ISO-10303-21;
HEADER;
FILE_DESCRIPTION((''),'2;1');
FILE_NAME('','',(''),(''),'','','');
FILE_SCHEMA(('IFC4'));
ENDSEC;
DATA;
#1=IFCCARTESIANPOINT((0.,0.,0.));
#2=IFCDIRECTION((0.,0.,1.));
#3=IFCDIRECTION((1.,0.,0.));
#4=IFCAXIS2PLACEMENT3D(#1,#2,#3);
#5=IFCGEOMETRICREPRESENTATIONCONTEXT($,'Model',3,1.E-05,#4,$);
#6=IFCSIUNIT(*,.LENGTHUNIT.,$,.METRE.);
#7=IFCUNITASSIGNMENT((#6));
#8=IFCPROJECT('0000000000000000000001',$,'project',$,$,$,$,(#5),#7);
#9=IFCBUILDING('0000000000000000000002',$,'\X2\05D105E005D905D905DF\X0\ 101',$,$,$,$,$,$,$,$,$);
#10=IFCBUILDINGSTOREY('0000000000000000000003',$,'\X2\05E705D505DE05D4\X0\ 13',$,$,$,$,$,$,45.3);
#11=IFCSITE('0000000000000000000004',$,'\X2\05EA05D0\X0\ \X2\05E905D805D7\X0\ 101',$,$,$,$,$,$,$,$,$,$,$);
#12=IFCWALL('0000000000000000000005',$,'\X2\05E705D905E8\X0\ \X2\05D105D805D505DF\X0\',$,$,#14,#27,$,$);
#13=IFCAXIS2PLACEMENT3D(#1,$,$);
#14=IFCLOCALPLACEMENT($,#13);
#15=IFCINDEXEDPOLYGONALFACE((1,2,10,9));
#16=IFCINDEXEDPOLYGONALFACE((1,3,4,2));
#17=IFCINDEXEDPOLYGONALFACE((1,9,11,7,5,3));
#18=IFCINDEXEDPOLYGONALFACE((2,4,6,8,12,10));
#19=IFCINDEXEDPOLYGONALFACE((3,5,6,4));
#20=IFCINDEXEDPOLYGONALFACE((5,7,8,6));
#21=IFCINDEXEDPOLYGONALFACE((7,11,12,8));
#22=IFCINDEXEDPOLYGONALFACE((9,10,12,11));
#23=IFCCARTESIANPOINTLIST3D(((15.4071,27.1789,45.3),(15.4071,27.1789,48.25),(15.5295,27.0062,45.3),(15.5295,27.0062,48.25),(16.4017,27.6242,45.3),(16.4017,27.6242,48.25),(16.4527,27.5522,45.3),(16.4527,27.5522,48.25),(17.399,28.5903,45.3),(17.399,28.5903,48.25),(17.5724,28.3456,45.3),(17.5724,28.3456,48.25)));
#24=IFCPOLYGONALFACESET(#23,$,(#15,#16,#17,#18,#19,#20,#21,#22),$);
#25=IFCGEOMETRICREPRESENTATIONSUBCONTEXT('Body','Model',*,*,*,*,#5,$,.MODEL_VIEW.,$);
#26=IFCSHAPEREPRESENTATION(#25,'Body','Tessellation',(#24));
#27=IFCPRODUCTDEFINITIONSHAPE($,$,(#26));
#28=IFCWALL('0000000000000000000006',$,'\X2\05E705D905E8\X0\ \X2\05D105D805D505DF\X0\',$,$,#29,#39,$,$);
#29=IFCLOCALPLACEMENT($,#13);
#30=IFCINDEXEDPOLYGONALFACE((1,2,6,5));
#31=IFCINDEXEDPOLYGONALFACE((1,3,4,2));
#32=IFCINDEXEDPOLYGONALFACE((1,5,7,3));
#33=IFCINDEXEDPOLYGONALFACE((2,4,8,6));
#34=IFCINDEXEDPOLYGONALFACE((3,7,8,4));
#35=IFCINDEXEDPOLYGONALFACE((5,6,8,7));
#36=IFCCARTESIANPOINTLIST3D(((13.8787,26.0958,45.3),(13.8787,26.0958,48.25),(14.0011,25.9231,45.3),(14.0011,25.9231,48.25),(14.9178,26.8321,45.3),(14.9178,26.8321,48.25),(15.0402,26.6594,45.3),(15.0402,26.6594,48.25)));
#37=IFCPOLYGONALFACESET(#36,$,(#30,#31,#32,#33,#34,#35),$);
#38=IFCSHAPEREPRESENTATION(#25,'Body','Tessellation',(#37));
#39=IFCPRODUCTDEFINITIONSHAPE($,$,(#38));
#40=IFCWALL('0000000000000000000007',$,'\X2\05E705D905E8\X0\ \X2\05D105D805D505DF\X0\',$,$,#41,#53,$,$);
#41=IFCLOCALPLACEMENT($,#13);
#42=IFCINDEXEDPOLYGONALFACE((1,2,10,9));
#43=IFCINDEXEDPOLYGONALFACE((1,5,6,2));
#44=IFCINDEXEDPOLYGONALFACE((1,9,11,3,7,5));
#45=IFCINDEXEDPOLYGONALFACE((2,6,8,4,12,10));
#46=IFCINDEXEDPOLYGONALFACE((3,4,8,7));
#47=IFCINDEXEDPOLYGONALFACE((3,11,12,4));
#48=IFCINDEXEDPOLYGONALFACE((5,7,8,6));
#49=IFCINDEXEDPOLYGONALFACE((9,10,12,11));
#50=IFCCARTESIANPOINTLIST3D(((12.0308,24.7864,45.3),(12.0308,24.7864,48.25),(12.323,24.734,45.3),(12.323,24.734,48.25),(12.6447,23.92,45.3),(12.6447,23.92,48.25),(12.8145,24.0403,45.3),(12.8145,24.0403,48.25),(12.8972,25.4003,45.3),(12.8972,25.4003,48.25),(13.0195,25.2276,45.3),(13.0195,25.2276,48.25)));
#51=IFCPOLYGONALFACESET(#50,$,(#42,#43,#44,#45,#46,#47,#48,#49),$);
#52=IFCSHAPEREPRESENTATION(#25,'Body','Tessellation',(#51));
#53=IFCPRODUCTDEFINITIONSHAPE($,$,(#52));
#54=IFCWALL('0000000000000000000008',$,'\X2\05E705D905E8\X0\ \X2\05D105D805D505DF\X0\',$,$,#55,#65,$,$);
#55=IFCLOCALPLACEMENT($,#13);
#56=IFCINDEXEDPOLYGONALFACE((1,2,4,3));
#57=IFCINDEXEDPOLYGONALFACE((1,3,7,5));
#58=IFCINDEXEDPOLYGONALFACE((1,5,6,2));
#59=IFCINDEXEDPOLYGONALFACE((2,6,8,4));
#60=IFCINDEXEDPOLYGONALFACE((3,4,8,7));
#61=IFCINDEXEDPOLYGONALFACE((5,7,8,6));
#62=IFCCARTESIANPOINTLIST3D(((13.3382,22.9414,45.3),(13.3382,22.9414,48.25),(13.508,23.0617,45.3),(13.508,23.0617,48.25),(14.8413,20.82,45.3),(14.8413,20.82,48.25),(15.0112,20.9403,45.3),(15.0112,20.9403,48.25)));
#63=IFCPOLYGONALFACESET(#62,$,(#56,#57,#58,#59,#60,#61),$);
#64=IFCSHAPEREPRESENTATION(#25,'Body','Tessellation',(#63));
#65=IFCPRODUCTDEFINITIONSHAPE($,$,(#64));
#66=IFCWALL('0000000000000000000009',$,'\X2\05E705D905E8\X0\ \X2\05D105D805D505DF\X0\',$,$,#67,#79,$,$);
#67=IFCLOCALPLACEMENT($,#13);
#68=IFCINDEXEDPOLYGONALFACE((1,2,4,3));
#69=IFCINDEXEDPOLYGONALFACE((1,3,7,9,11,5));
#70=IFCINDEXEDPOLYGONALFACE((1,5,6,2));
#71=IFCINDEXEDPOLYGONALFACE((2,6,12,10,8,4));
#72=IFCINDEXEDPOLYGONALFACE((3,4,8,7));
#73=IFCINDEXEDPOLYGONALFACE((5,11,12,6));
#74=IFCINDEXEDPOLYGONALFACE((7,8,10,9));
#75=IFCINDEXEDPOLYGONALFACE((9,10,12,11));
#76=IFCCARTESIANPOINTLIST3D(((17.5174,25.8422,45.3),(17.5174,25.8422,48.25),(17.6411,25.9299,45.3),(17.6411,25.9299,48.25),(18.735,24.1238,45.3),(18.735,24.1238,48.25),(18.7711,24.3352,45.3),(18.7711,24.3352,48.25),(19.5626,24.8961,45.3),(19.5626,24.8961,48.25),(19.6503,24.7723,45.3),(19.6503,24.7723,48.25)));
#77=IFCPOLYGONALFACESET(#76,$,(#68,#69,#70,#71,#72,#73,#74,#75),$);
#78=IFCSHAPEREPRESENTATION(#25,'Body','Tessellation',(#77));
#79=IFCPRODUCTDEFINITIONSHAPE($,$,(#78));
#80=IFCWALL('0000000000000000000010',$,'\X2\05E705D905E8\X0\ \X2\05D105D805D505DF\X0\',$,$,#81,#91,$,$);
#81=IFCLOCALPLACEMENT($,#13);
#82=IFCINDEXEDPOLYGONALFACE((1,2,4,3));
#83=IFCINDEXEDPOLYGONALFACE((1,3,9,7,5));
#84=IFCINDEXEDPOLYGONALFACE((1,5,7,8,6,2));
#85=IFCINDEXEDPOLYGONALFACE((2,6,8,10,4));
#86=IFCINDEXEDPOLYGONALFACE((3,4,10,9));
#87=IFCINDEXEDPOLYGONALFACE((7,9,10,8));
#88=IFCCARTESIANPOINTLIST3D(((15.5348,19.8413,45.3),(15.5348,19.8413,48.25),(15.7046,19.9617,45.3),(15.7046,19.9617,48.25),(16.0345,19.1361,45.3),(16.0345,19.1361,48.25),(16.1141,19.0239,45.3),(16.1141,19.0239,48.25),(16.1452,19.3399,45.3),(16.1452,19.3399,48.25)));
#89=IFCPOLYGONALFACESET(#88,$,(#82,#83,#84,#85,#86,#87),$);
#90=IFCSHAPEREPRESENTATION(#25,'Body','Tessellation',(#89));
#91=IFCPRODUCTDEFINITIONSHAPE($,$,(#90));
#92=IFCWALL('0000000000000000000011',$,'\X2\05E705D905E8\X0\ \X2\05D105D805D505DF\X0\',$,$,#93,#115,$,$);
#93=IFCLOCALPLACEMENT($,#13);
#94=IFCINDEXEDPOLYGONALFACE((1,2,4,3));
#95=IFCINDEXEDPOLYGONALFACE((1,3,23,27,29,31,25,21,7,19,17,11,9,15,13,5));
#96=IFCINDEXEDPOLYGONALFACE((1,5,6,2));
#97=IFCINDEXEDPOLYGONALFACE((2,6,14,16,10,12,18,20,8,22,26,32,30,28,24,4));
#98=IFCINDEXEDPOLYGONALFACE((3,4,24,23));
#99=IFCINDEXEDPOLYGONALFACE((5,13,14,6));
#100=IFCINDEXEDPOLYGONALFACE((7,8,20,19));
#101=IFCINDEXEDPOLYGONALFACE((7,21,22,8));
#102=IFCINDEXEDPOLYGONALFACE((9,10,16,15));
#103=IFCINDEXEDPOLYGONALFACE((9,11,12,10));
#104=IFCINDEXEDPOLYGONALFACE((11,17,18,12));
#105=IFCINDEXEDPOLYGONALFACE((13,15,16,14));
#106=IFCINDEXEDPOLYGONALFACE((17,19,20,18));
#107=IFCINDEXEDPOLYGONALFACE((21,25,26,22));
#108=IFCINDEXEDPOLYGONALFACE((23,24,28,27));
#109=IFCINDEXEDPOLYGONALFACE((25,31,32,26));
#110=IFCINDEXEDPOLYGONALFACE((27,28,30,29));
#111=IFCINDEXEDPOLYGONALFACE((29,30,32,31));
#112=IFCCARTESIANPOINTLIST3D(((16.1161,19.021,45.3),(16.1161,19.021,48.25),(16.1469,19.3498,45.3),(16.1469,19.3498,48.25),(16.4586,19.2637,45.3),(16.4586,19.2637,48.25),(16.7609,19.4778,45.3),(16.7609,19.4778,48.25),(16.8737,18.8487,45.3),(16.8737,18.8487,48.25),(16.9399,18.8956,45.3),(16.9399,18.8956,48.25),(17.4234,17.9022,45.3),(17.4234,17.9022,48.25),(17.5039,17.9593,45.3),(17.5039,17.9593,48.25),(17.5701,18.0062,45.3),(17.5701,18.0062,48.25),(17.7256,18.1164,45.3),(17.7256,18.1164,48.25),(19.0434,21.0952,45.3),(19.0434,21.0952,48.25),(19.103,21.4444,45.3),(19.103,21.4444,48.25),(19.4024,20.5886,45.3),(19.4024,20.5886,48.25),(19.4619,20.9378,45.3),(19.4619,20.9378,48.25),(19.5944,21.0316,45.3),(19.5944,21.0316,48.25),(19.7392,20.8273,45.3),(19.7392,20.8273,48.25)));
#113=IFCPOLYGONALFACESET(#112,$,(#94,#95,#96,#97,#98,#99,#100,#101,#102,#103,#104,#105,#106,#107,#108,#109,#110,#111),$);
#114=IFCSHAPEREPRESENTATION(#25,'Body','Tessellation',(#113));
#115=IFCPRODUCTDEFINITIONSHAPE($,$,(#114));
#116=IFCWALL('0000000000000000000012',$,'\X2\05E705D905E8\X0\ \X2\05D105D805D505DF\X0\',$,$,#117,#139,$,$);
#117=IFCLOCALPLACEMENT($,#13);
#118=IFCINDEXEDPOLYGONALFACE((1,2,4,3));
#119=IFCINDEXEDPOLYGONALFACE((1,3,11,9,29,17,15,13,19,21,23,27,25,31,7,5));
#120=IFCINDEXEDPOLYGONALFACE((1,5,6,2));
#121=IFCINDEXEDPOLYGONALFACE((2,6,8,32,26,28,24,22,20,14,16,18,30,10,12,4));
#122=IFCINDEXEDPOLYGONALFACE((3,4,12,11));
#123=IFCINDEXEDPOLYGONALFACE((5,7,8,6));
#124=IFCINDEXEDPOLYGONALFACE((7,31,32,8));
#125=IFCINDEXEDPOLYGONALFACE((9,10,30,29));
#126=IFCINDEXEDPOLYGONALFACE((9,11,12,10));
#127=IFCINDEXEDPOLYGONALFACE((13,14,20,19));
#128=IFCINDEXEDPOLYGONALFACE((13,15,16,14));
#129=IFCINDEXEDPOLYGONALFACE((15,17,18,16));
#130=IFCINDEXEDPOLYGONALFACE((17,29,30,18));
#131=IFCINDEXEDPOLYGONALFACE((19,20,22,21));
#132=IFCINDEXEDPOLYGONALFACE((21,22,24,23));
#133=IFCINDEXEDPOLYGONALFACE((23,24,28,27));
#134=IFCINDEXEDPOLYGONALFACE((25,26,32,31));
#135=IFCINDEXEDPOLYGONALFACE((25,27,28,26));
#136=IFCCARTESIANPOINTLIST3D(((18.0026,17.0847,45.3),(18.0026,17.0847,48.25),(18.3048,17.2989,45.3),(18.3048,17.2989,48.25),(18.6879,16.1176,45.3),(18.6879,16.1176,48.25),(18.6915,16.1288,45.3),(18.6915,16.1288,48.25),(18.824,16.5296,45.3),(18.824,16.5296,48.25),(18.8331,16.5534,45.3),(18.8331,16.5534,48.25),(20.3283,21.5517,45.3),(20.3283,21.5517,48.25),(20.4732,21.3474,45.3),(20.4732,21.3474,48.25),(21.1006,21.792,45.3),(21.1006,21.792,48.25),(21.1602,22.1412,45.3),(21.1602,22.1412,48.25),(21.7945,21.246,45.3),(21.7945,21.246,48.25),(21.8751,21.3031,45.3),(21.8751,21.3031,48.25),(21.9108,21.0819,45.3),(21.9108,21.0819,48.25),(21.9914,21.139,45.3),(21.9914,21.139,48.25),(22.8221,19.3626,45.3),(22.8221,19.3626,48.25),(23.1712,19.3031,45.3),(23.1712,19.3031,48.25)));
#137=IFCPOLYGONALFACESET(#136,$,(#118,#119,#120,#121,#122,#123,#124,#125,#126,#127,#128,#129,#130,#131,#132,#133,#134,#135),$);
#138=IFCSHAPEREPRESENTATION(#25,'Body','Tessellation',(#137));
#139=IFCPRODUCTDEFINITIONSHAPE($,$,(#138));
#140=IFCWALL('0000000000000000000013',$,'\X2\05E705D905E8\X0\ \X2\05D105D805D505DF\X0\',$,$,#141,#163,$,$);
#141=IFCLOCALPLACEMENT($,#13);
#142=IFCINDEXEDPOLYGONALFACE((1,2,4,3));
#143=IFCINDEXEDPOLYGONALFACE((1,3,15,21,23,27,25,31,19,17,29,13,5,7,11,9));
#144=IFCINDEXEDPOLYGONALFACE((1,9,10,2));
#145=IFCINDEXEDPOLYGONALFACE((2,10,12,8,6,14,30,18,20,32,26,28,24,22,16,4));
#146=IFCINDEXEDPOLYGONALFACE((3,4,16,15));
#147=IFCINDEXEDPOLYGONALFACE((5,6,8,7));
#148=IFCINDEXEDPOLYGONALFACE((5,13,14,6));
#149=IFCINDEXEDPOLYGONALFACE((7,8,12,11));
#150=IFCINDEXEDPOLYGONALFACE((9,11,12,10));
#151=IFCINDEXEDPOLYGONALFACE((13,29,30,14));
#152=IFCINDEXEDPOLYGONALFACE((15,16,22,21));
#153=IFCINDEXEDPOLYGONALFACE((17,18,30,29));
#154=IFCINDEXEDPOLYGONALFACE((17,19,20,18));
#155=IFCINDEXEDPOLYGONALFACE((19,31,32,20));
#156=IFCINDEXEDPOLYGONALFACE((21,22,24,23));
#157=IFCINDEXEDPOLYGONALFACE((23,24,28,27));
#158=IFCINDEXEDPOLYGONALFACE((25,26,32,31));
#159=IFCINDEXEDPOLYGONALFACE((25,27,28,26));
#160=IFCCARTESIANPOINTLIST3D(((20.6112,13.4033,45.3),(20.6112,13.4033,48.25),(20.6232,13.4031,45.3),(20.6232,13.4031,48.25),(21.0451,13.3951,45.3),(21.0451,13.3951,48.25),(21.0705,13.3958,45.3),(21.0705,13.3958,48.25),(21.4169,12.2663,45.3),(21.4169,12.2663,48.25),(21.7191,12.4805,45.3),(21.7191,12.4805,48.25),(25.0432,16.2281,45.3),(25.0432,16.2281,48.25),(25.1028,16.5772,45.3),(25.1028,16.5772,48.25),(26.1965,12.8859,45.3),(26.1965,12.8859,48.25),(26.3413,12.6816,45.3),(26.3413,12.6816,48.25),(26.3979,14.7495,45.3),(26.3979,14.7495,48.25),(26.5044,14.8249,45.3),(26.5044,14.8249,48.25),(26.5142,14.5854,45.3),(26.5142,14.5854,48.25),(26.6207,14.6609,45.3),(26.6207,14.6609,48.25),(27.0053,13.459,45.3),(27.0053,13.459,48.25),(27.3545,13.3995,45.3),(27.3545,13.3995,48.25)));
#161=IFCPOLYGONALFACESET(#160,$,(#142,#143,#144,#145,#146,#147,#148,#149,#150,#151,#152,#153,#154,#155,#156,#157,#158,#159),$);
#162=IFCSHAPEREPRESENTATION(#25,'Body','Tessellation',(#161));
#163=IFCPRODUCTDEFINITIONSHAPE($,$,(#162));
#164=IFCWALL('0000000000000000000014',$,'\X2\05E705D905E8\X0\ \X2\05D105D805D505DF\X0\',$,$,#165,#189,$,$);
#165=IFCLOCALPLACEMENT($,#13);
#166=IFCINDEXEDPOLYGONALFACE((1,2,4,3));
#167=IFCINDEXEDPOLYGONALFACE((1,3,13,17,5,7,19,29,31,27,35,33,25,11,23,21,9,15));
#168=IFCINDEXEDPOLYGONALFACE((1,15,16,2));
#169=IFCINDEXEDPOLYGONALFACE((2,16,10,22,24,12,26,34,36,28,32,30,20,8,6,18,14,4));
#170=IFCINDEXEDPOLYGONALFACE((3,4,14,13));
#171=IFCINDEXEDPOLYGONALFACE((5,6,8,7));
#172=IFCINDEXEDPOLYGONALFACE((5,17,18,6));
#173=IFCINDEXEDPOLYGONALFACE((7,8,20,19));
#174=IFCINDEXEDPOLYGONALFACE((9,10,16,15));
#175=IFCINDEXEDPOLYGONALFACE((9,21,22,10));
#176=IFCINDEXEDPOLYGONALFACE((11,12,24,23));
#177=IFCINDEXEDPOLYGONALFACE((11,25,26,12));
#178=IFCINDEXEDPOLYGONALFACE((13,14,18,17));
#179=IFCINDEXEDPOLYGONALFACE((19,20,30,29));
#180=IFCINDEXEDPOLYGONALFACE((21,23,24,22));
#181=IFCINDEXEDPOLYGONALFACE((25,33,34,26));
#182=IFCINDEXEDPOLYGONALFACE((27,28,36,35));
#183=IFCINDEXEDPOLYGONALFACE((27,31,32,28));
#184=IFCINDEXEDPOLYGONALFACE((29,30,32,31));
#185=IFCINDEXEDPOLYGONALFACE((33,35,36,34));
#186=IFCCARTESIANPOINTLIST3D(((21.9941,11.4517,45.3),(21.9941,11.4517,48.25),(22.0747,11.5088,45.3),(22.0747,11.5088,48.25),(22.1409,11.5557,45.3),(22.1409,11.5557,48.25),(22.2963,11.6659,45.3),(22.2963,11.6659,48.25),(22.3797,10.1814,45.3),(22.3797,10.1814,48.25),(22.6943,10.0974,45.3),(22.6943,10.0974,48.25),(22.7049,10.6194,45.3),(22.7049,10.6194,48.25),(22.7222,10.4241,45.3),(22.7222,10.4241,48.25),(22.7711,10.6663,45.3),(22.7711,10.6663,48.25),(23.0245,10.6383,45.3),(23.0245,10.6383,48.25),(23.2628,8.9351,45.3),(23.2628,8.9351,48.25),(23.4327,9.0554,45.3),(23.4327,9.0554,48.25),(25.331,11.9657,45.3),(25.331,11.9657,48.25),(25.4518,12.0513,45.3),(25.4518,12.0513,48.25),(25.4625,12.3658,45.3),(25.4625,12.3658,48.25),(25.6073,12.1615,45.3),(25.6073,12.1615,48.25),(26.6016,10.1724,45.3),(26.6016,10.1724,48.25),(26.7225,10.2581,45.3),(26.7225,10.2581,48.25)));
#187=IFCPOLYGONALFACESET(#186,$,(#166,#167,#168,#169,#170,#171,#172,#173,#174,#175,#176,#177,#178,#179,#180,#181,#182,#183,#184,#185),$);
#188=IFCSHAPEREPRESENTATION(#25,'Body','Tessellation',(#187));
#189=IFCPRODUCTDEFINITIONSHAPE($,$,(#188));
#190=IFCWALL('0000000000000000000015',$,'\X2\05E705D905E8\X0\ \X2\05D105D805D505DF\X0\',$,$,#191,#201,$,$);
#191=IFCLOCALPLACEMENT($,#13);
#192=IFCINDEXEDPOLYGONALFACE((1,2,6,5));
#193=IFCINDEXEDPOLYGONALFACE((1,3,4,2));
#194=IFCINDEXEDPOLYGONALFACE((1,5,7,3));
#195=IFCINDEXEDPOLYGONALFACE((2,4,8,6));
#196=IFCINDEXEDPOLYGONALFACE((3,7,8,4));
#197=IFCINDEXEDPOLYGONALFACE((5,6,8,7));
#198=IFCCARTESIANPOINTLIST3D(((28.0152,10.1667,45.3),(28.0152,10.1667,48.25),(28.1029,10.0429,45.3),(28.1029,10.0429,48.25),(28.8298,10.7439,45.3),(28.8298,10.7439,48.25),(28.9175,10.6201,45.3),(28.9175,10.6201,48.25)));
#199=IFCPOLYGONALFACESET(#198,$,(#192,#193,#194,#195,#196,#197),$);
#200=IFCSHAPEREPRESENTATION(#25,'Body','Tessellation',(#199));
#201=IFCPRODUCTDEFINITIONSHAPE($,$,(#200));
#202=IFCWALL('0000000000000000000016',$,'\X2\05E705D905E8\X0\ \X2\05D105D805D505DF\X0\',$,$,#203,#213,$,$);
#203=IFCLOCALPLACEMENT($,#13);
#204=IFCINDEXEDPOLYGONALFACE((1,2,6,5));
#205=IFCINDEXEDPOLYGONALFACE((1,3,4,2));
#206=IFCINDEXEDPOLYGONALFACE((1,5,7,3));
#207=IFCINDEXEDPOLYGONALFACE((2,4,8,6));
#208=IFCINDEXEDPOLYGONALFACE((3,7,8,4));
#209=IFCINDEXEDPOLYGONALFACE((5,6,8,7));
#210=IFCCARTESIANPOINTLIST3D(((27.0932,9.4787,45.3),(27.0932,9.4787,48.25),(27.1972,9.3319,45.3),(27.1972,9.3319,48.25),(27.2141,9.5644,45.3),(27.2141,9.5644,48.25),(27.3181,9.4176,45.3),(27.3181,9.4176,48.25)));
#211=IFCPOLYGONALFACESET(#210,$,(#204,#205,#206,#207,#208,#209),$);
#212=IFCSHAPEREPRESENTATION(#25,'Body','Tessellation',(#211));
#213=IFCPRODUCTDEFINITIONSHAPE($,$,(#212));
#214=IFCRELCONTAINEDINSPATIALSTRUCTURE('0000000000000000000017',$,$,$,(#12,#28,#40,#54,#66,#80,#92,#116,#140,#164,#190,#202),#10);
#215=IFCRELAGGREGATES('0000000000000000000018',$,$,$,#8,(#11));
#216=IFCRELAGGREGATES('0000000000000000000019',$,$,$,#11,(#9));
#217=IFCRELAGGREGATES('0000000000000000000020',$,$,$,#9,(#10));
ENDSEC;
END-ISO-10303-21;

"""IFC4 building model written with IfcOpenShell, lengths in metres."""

from ifc_helpers import new_model, si_unit, frame, origin_with_axes, context, subcontext, project, spatial, polyline, outline, extrude, element, save


model = new_model("IFC4")

# Units and contexts
model_context = context("Model", 3, precision=1e-05, world=origin_with_axes())
body_context = subcontext(model_context, "Body", "Model", "MODEL_VIEW")
ifc_project = project(units=[si_unit("LENGTHUNIT", "METRE")], contexts=[model_context])

# Site, building, storey
site = spatial("IfcSite", under=ifc_project, Name="תא שטח 101")
building = spatial("IfcBuilding", under=site, Name="בניין 101")
storey = spatial("IfcBuildingStorey", under=building, Name="קומה 13", Elevation=45.3)

# Walls
element("IfcWall", 1, inside=storey, Name="קיר בטון", context=body_context, shape_type="SweptSolid", body=[
    extrude(outline(polyline([(16.4017, 27.6242), (16.4527, 27.5522), (17.5724, 28.3456), (17.399, 28.5903), (15.4071, 27.1789), (15.5295, 27.0062), (16.4017, 27.6242)])), frame((0.0, 0.0, 45.3)), (0.0, 0.0, 1.0), 2.95),
])
element("IfcWall", 2, inside=storey, Name="קיר בטון", context=body_context, shape_type="SweptSolid", body=[
    extrude(outline(polyline([(14.9178, 26.8321), (13.8787, 26.0958), (14.0011, 25.9231), (15.0402, 26.6594), (14.9178, 26.8321)])), frame((0.0, 0.0, 45.3)), (0.0, 0.0, 1.0), 2.95),
])
element("IfcWall", 3, inside=storey, Name="קיר בטון", context=body_context, shape_type="SweptSolid", body=[
    extrude(outline(polyline([(12.323, 24.734), (13.0195, 25.2276), (12.8972, 25.4003), (12.0308, 24.7864), (12.6447, 23.92), (12.8145, 24.0403), (12.323, 24.734)])), frame((0.0, 0.0, 45.3)), (0.0, 0.0, 1.0), 2.95),
])
element("IfcWall", 4, inside=storey, Name="קיר בטון", context=body_context, shape_type="SweptSolid", body=[
    extrude(outline(polyline([(14.8413, 20.82), (15.0112, 20.9403), (13.508, 23.0617), (13.3382, 22.9414), (14.8413, 20.82)])), frame((0.0, 0.0, 45.3)), (0.0, 0.0, 1.0), 2.95),
])
element("IfcWall", 5, inside=storey, Name="קיר בטון", context=body_context, shape_type="SweptSolid", body=[
    extrude(outline(polyline([(18.735, 24.1238), (19.6503, 24.7723), (19.5626, 24.8961), (18.7711, 24.3352), (17.6411, 25.9299), (17.5174, 25.8422), (18.735, 24.1238)])), frame((0.0, 0.0, 45.3)), (0.0, 0.0, 1.0), 2.95),
])
element("IfcWall", 6, inside=storey, Name="קיר בטון", context=body_context, shape_type="SweptSolid", body=[
    extrude(outline(polyline([(15.5348, 19.8413), (16.0345, 19.1361), (16.1141, 19.0239), (16.1452, 19.3399), (15.7046, 19.9617), (15.5348, 19.8413)])), frame((0.0, 0.0, 45.3)), (0.0, 0.0, 1.0), 2.95),
])
element("IfcWall", 7, inside=storey, Name="קיר בטון", context=body_context, shape_type="SweptSolid", body=[
    extrude(outline(polyline([(19.4024, 20.5886), (19.7392, 20.8273), (19.5944, 21.0316), (19.4619, 20.9378), (19.103, 21.4444), (16.1469, 19.3498), (16.1161, 19.021), (16.4586, 19.2637), (17.4234, 17.9022), (17.5039, 17.9593), (16.8737, 18.8487), (16.9399, 18.8956), (17.5701, 18.0062), (17.7256, 18.1164), (16.7609, 19.4778), (19.0434, 21.0952), (19.4024, 20.5886)])), frame((0.0, 0.0, 45.3)), (0.0, 0.0, 1.0), 2.95),
])
element("IfcWall", 8, inside=storey, Name="קיר בטון", context=body_context, shape_type="SweptSolid", body=[
    extrude(outline(polyline([(21.1602, 22.1412), (20.3283, 21.5517), (20.4732, 21.3474), (21.1006, 21.792), (22.8221, 19.3626), (18.824, 16.5296), (18.8331, 16.5534), (18.3048, 17.2989), (18.0026, 17.0847), (18.6879, 16.1176), (18.758, 16.3359), (18.6896, 16.1274), (23.1712, 19.3031), (21.9108, 21.0819), (21.9914, 21.139), (21.8751, 21.3031), (21.7945, 21.246), (21.8822, 21.1222), (21.1602, 22.1412)])), frame((0.0, 0.0, 45.3)), (0.0, 0.0, 1.0), 2.95),
])
element("IfcWall", 9, inside=storey, Name="קיר בטון", context=body_context, shape_type="SweptSolid", body=[
    extrude(outline(polyline([(20.8384, 13.3999), (20.6112, 13.4033), (21.4169, 12.2663), (21.7191, 12.4805), (21.0705, 13.3958), (21.0451, 13.3951), (25.0432, 16.2281), (27.0053, 13.459), (26.1965, 12.8859), (26.3413, 12.6816), (27.3545, 13.3995), (26.5142, 14.5854), (26.6207, 14.6609), (26.5044, 14.8249), (26.3979, 14.7495), (25.1028, 16.5772), (20.6211, 13.4016), (20.8384, 13.3999)])), frame((0.0, 0.0, 45.3)), (0.0, 0.0, 1.0), 2.95),
])
element("IfcWall", 10, inside=storey, Name="קיר בטון", context=body_context, shape_type="SweptSolid", body=[
    extrude(outline(polyline([(22.7222, 10.4241), (22.3797, 10.1814), (23.2628, 8.9351), (23.4327, 9.0554), (22.6943, 10.0974), (25.331, 11.9657), (26.6016, 10.1724), (26.7225, 10.2581), (25.4518, 12.0513), (25.6073, 12.1615), (25.4625, 12.3658), (23.0245, 10.6383), (22.2963, 11.6659), (22.1409, 11.5557), (22.7711, 10.6663), (22.7049, 10.6194), (22.0747, 11.5088), (21.9941, 11.4517), (22.7222, 10.4241)])), frame((0.0, 0.0, 45.3)), (0.0, 0.0, 1.0), 2.95),
])
element("IfcWall", 11, inside=storey, Name="קיר בטון", context=body_context, shape_type="SweptSolid", body=[
    extrude(outline(polyline([(28.9175, 10.6201), (28.8298, 10.7439), (28.0152, 10.1667), (28.1029, 10.0429), (28.9175, 10.6201)])), frame((0.0, 0.0, 45.3)), (0.0, 0.0, 1.0), 2.95),
])
element("IfcWall", 12, inside=storey, Name="קיר בטון", context=body_context, shape_type="SweptSolid", body=[
    extrude(outline(polyline([(27.2141, 9.5644), (27.0932, 9.4787), (27.1972, 9.3319), (27.3181, 9.4176), (27.2141, 9.5644)])), frame((0.0, 0.0, 45.3)), (0.0, 0.0, 1.0), 2.95),
])

save(model, "model.ifc")
